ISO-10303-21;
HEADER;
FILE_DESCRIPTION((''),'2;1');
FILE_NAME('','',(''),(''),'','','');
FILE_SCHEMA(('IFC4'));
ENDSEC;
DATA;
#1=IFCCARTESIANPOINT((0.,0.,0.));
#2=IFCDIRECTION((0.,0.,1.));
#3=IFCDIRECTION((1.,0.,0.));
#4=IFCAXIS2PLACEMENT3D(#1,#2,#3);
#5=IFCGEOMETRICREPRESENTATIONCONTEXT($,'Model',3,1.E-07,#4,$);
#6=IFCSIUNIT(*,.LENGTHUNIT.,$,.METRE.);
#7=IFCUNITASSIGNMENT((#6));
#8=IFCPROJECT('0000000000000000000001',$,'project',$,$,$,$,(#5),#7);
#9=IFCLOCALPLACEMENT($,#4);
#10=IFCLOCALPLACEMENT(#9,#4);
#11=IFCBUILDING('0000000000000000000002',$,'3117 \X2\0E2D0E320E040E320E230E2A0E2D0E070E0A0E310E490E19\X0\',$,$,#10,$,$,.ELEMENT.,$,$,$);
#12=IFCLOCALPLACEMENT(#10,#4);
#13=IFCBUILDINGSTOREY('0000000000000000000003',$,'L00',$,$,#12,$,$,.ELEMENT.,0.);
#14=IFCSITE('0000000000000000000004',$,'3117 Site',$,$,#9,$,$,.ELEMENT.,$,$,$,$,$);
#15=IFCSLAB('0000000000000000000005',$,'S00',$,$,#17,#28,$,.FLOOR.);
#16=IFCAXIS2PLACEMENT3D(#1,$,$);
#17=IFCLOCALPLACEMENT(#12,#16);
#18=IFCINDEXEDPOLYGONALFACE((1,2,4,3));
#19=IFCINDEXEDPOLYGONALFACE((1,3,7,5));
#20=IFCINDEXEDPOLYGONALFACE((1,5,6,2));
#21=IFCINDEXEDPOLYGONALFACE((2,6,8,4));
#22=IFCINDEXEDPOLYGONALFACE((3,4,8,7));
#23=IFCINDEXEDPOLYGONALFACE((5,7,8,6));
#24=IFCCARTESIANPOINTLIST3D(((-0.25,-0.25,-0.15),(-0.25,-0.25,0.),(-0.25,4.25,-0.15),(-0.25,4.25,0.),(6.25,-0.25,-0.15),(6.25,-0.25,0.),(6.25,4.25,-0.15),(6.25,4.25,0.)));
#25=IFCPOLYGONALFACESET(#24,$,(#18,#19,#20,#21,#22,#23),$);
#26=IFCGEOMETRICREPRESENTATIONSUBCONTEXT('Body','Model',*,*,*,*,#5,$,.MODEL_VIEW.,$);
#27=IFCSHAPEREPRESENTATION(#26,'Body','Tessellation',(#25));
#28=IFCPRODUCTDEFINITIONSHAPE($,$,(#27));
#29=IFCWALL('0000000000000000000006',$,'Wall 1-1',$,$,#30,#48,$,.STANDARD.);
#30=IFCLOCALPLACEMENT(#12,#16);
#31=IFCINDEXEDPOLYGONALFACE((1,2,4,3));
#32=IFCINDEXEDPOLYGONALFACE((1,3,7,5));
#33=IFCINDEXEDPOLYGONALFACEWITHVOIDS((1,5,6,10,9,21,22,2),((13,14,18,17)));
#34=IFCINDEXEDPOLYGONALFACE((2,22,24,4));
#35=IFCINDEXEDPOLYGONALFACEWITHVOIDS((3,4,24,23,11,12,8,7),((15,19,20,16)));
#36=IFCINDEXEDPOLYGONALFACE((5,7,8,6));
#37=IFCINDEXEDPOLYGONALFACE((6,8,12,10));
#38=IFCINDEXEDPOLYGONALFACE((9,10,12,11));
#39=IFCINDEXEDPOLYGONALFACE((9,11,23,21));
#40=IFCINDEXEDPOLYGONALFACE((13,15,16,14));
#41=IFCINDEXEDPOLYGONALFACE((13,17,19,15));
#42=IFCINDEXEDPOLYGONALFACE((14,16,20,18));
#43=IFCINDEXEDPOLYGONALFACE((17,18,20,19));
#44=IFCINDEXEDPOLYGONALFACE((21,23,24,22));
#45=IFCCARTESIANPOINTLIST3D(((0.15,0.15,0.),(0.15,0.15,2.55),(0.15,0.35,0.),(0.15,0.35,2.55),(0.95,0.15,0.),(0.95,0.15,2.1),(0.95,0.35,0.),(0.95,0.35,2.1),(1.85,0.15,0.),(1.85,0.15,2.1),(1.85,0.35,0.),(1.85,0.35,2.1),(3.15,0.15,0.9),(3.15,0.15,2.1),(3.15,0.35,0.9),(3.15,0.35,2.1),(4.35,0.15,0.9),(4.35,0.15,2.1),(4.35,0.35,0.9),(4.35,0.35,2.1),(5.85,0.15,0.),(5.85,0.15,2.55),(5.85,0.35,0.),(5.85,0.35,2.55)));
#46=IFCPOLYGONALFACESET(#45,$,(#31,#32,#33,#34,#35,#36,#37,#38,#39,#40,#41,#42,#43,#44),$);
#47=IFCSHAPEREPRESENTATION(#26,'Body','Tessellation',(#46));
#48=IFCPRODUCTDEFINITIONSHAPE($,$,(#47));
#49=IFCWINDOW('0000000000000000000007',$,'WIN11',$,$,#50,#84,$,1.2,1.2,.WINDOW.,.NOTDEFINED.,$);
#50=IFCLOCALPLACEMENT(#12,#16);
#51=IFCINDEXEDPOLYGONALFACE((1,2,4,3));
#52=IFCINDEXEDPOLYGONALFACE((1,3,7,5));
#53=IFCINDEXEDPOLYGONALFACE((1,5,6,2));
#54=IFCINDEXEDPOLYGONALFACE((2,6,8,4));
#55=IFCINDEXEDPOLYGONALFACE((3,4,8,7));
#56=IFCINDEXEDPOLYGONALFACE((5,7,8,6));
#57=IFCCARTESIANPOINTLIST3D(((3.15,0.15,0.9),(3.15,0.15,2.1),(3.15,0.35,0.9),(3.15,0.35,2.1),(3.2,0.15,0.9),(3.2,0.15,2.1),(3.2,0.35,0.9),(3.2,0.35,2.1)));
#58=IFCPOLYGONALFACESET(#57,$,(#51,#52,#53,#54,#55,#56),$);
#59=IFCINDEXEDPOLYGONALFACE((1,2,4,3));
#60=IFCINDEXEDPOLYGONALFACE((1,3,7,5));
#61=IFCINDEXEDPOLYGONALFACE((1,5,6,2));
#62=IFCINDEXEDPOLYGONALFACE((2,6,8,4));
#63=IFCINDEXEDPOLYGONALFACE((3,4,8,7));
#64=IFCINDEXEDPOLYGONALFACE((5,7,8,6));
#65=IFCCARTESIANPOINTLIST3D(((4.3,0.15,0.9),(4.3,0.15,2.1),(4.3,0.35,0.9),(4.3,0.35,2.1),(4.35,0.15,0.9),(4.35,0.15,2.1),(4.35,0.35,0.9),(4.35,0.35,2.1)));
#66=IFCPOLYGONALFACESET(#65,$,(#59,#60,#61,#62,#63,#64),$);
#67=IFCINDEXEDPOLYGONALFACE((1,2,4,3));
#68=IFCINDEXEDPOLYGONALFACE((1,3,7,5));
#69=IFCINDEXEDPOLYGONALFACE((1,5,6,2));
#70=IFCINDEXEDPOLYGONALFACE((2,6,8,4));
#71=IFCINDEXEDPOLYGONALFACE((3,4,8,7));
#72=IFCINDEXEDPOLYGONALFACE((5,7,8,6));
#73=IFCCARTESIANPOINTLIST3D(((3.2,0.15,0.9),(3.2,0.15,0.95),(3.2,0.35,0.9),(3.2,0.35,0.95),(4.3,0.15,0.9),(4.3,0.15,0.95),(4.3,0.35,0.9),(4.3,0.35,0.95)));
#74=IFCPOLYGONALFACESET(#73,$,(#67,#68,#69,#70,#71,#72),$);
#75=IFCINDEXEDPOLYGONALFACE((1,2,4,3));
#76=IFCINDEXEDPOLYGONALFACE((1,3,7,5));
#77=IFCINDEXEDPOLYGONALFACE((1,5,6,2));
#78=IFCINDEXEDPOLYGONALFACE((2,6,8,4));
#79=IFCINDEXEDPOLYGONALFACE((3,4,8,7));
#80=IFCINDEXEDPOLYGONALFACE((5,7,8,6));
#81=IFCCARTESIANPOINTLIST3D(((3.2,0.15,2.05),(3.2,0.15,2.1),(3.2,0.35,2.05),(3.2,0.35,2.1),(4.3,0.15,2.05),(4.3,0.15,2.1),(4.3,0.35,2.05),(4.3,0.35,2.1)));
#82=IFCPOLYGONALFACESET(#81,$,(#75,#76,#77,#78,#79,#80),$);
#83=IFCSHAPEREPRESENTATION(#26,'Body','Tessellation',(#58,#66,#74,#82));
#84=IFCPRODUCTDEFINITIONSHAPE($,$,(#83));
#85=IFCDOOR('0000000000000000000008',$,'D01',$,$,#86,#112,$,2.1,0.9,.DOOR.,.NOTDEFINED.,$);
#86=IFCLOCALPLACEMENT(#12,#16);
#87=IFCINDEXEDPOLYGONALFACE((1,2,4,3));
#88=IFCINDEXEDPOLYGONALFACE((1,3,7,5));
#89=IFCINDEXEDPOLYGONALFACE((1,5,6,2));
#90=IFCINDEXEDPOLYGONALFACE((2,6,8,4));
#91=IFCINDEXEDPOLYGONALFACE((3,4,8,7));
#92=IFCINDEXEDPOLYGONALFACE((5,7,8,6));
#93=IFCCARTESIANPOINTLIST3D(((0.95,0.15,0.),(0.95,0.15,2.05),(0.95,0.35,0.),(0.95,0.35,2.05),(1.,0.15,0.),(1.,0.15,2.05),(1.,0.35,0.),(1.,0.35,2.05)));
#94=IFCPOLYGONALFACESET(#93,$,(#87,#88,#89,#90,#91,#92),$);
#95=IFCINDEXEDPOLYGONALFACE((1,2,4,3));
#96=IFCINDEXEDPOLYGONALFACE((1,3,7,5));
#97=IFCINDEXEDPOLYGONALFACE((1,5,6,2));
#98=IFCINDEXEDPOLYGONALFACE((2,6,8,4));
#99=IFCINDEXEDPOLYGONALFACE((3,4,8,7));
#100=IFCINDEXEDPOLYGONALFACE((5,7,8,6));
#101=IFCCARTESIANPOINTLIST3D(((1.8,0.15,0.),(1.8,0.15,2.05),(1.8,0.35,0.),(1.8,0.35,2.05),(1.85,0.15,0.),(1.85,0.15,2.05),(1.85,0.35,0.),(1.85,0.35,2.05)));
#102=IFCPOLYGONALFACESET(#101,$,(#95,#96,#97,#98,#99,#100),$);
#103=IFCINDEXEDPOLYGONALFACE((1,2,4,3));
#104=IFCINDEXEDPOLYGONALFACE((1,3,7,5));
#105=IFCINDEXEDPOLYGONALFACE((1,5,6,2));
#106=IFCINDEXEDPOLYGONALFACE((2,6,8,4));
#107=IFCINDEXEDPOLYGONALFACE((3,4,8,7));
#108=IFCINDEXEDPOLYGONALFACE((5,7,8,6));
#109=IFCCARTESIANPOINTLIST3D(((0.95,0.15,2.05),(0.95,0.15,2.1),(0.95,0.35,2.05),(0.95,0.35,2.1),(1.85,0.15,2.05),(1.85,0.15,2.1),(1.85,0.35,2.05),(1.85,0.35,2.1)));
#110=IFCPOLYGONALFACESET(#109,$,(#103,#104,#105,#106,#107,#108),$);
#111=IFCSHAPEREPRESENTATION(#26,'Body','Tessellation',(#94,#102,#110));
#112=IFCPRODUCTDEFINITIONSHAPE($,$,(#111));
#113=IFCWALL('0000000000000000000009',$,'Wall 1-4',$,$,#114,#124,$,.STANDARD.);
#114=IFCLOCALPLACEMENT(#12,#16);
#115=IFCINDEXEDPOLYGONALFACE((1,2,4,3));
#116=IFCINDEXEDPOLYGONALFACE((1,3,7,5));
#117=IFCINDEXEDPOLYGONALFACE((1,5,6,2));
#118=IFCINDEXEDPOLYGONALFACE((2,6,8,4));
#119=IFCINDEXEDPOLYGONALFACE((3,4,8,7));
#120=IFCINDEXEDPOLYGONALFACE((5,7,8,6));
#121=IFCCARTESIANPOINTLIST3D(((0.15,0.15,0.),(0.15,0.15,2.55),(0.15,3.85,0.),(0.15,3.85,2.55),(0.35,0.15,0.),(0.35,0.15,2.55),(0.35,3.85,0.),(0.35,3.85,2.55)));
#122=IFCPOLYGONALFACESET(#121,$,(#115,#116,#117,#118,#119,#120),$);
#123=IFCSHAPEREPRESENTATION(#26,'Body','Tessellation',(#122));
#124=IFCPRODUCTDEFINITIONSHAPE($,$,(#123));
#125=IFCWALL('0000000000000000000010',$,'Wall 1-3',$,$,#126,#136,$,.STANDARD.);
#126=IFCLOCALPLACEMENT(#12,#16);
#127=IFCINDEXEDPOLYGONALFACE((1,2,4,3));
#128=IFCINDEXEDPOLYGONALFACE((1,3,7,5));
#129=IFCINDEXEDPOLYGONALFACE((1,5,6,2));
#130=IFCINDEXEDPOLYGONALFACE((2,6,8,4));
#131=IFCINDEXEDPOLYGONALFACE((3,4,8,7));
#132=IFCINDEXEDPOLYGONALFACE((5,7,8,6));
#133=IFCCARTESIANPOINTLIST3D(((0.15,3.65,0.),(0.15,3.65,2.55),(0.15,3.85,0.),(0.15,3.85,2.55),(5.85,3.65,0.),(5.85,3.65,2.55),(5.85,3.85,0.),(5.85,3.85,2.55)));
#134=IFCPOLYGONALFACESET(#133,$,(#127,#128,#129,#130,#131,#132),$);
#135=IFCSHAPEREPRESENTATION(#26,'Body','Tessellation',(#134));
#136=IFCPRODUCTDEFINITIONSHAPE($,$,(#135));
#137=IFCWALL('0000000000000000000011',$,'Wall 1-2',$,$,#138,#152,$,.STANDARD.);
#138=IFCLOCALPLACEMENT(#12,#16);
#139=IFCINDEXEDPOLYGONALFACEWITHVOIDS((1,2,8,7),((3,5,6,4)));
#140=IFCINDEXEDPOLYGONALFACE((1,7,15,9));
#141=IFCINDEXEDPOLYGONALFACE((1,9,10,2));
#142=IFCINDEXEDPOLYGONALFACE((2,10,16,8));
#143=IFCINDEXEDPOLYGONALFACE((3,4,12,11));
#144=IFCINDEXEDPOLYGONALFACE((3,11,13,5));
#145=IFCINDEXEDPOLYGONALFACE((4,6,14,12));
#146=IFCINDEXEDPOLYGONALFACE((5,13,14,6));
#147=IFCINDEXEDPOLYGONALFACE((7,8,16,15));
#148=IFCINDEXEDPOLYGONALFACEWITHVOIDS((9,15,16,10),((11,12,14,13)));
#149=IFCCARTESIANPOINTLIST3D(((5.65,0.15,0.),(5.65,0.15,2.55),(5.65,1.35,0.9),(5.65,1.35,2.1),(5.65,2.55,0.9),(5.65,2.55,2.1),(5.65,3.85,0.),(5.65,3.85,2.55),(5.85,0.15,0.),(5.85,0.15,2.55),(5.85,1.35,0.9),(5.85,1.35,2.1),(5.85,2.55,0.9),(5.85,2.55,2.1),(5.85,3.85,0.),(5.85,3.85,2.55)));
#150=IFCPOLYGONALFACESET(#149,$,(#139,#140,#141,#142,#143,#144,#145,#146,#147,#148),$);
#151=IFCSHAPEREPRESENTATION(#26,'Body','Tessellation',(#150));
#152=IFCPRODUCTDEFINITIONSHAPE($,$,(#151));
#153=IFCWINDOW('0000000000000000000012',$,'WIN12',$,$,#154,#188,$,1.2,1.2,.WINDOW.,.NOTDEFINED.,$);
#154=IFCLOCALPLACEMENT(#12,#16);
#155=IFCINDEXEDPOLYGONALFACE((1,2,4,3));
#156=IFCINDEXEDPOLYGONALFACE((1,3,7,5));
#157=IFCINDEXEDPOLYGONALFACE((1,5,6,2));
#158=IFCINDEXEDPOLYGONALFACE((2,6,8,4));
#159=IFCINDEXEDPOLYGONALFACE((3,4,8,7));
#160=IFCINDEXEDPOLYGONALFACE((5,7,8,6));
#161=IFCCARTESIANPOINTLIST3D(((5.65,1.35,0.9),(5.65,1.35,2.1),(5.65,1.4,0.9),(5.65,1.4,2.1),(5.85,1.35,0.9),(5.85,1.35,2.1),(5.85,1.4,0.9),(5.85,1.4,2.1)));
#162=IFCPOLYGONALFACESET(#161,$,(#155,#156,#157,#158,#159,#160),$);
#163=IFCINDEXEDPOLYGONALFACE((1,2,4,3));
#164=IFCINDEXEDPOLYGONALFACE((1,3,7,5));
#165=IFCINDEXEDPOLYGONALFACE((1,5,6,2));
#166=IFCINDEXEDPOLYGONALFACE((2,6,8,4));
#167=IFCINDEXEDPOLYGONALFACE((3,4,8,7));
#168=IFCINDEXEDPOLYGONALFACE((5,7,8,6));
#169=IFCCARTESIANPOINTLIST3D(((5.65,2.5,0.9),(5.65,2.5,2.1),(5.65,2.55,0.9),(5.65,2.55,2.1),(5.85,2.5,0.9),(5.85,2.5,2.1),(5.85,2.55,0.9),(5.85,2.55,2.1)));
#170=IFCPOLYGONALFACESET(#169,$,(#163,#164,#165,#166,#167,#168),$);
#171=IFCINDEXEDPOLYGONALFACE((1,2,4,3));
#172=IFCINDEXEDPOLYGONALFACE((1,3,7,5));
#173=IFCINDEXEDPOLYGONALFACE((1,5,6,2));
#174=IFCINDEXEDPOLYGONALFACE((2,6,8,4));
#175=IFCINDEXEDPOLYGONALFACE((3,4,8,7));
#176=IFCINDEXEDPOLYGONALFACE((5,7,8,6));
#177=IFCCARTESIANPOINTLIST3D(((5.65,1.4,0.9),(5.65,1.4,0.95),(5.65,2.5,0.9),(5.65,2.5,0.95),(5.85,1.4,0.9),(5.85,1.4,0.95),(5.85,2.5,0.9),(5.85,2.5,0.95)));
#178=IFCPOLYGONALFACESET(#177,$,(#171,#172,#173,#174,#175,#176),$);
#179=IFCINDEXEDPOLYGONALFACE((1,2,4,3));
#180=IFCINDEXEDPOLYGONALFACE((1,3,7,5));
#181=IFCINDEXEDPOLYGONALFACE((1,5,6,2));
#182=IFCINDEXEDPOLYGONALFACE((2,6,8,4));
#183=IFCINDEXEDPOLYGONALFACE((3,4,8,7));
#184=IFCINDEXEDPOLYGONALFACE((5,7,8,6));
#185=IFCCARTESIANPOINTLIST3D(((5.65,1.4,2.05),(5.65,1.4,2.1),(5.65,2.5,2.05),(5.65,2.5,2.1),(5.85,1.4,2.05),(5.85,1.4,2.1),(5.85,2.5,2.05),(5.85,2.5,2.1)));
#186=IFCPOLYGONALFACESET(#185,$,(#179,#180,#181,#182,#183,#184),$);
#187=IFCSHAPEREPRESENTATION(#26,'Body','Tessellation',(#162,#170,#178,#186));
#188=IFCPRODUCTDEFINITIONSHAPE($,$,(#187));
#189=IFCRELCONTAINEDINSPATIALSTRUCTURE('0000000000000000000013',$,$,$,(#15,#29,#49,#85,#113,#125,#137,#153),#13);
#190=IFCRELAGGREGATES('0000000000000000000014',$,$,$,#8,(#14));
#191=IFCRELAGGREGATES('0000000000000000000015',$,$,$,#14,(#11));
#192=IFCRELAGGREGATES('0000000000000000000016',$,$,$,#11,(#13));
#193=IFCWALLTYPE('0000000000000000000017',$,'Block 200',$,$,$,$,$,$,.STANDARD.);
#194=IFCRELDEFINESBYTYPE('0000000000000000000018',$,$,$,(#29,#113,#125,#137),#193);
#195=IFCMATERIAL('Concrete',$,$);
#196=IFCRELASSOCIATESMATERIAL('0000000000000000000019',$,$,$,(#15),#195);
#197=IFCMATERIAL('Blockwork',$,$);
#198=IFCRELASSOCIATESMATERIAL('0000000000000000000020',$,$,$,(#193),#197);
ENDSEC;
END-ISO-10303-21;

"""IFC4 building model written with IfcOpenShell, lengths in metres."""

from ifc_helpers import new_model, si_unit, frame, origin_with_axes, place, context, subcontext, project, spatial, polyline, outline, extrude, material, type_object, element, fill, save


model = new_model("IFC4")

# Units and contexts
model_context = context("Model", 3, precision=1e-07, world=origin_with_axes())
body_context = subcontext(model_context, "Body", "Model", "MODEL_VIEW")
ifc_project = project(units=[si_unit("LENGTHUNIT", "METRE")], contexts=[model_context])

# Site, building, storey
site_placement = place(None, origin_with_axes())
site = spatial("IfcSite", under=ifc_project, at=site_placement, Name="3117 Site", CompositionType="ELEMENT")
building_placement = place(site_placement, origin_with_axes())
building = spatial("IfcBuilding", under=site, at=building_placement, Name="3117 อาคารสองชั้น", CompositionType="ELEMENT")
storey_placement = place(building_placement, origin_with_axes())
storey = spatial("IfcBuildingStorey", under=building, at=storey_placement, Name="L00", CompositionType="ELEMENT", Elevation=0.0)

# Slab
ifc_material_1 = material(Name="Concrete")
slab_placement = place(storey_placement, frame((0.0, 0.0, -0.15), z_axis=(0.0, 0.0, 1.0), x_axis=(1.0, 0.0, 0.0)))
element("IfcSlab", 1, at=slab_placement, inside=storey, material=ifc_material_1, Name="S00", PredefinedType="FLOOR", context=body_context, shape_type="SweptSolid", body=[
    extrude(outline(polyline([(-0.25, -0.25), (6.25, -0.25), (6.25, 4.25), (-0.25, 4.25), (-0.25, -0.25)])), origin_with_axes(), (0.0, 0.0, 1.0), 0.15),
])

# Wall, openings, window, door
ifc_material_2 = material(Name="Blockwork")
wall_type = type_object("IfcWallType", Name="Block 200", PredefinedType="STANDARD", material=ifc_material_2)
wall_1_placement = place(storey_placement, frame((0.15, 0.15, 0.0), z_axis=(0.0, 0.0, 1.0), x_axis=(1.0, 0.0, 0.0)))
wall_1 = element("IfcWall", 2, at=wall_1_placement, inside=storey, type_object=wall_type, Name="Wall 1-1", PredefinedType="STANDARD", context=body_context, shape_type="SweptSolid", body=[
    extrude(outline(polyline([(0.0, 0.0), (5.7, 0.0), (5.7, 0.2), (0.0, 0.2), (0.0, 0.0)])), origin_with_axes(), (0.0, 0.0, 1.0), 2.55),
])
opening_1_placement = place(wall_1_placement, frame((3.0, 0.0, 0.9), z_axis=(0.0, 0.0, 1.0), x_axis=(1.0, 0.0, 0.0)))
opening_1 = element("IfcOpeningElement", 3, at=opening_1_placement, cuts=wall_1, PredefinedType="OPENING", context=body_context, shape_type="SweptSolid", body=[
    extrude(outline(polyline([(0.0, 0.0), (1.2, 0.0), (1.2, 0.2), (0.0, 0.2), (0.0, 0.0)])), origin_with_axes(), (0.0, 0.0, 1.0), 1.2),
])
opening_2_placement = place(wall_1_placement, frame((0.8, 0.0, 0.0), z_axis=(0.0, 0.0, 1.0), x_axis=(1.0, 0.0, 0.0)))
opening_2 = element("IfcOpeningElement", 4, at=opening_2_placement, cuts=wall_1, PredefinedType="OPENING", context=body_context, shape_type="SweptSolid", body=[
    extrude(outline(polyline([(0.0, 0.0), (0.9, 0.0), (0.9, 0.2), (0.0, 0.2), (0.0, 0.0)])), origin_with_axes(), (0.0, 0.0, 1.0), 2.1),
])
window_1_placement = place(opening_1_placement, frame((0.0, 0.0, 0.0), z_axis=(0.0, 0.0, 1.0), x_axis=(1.0, 0.0, 0.0)))
window_1 = element("IfcWindow", 5, at=window_1_placement, inside=storey, Name="WIN11", OverallHeight=1.2, OverallWidth=1.2, PartitioningType="NOTDEFINED", PredefinedType="WINDOW", context=body_context, shape_type="SweptSolid", body=[
    extrude(outline(polyline([(0.0, 0.0), (0.05, 0.0), (0.05, 0.2), (0.0, 0.2), (0.0, 0.0)])), origin_with_axes(), (0.0, 0.0, 1.0), 1.2),
    extrude(outline(polyline([(0.0, 0.0), (0.05, 0.0), (0.05, 0.2), (0.0, 0.2), (0.0, 0.0)])), frame((1.15, 0.0, 0.0), z_axis=(0.0, 0.0, 1.0), x_axis=(1.0, 0.0, 0.0)), (0.0, 0.0, 1.0), 1.2),
    extrude(outline(polyline([(0.0, 0.0), (1.1, 0.0), (1.1, 0.2), (0.0, 0.2), (0.0, 0.0)])), frame((0.05, 0.0, 0.0), z_axis=(0.0, 0.0, 1.0), x_axis=(1.0, 0.0, 0.0)), (0.0, 0.0, 1.0), 0.05),
    extrude(outline(polyline([(0.0, 0.0), (1.1, 0.0), (1.1, 0.2), (0.0, 0.2), (0.0, 0.0)])), frame((0.05, 0.0, 1.15), z_axis=(0.0, 0.0, 1.0), x_axis=(1.0, 0.0, 0.0)), (0.0, 0.0, 1.0), 0.05),
])
fill(opening_1, window_1)
door_placement = place(opening_2_placement, frame((0.0, 0.0, 0.0), z_axis=(0.0, 0.0, 1.0), x_axis=(1.0, 0.0, 0.0)))
door = element("IfcDoor", 6, at=door_placement, inside=storey, Name="D01", OperationType="NOTDEFINED", OverallHeight=2.1, OverallWidth=0.9, PredefinedType="DOOR", context=body_context, shape_type="SweptSolid", body=[
    extrude(outline(polyline([(0.0, 0.0), (0.05, 0.0), (0.05, 0.2), (0.0, 0.2), (0.0, 0.0)])), origin_with_axes(), (0.0, 0.0, 1.0), 2.05),
    extrude(outline(polyline([(0.0, 0.0), (0.05, 0.0), (0.05, 0.2), (0.0, 0.2), (0.0, 0.0)])), frame((0.85, 0.0, 0.0), z_axis=(0.0, 0.0, 1.0), x_axis=(1.0, 0.0, 0.0)), (0.0, 0.0, 1.0), 2.05),
    extrude(outline(polyline([(0.0, 0.0), (0.9, 0.0), (0.9, 0.2), (0.0, 0.2), (0.0, 0.0)])), frame((0.0, 0.0, 2.05), z_axis=(0.0, 0.0, 1.0), x_axis=(1.0, 0.0, 0.0)), (0.0, 0.0, 1.0), 0.05),
])
fill(opening_2, door)

# Walls
wall_2_placement = place(storey_placement, frame((0.15, 3.85, 0.0), z_axis=(0.0, 0.0, 1.0), x_axis=(0.0, -1.0, 0.0)))
element("IfcWall", 7, at=wall_2_placement, inside=storey, type_object=wall_type, Name="Wall 1-4", PredefinedType="STANDARD", context=body_context, shape_type="SweptSolid", body=[
    extrude(outline(polyline([(0.0, 0.0), (3.7, 0.0), (3.7, 0.2), (0.0, 0.2), (0.0, 0.0)])), origin_with_axes(), (0.0, 0.0, 1.0), 2.55),
])
wall_3_placement = place(storey_placement, frame((5.85, 3.85, 0.0), z_axis=(0.0, 0.0, 1.0), x_axis=(-1.0, 0.0, 0.0)))
element("IfcWall", 8, at=wall_3_placement, inside=storey, type_object=wall_type, Name="Wall 1-3", PredefinedType="STANDARD", context=body_context, shape_type="SweptSolid", body=[
    extrude(outline(polyline([(0.0, 0.0), (5.7, 0.0), (5.7, 0.2), (0.0, 0.2), (0.0, 0.0)])), origin_with_axes(), (0.0, 0.0, 1.0), 2.55),
])

# Wall, opening, window
wall_4_placement = place(storey_placement, frame((5.85, 0.15, 0.0), z_axis=(0.0, 0.0, 1.0), x_axis=(0.0, 1.0, 0.0)))
wall_4 = element("IfcWall", 9, at=wall_4_placement, inside=storey, type_object=wall_type, Name="Wall 1-2", PredefinedType="STANDARD", context=body_context, shape_type="SweptSolid", body=[
    extrude(outline(polyline([(0.0, 0.0), (3.7, 0.0), (3.7, 0.2), (0.0, 0.2), (0.0, 0.0)])), origin_with_axes(), (0.0, 0.0, 1.0), 2.55),
])
opening_3_placement = place(wall_4_placement, frame((1.2, 0.0, 0.9), z_axis=(0.0, 0.0, 1.0), x_axis=(1.0, 0.0, 0.0)))
opening_3 = element("IfcOpeningElement", 10, at=opening_3_placement, cuts=wall_4, PredefinedType="OPENING", context=body_context, shape_type="SweptSolid", body=[
    extrude(outline(polyline([(0.0, 0.0), (1.2, 0.0), (1.2, 0.2), (0.0, 0.2), (0.0, 0.0)])), origin_with_axes(), (0.0, 0.0, 1.0), 1.2),
])
window_2_placement = place(opening_3_placement, frame((0.0, 0.0, 0.0), z_axis=(0.0, 0.0, 1.0), x_axis=(1.0, 0.0, 0.0)))
window_2 = element("IfcWindow", 11, at=window_2_placement, inside=storey, Name="WIN12", OverallHeight=1.2, OverallWidth=1.2, PartitioningType="NOTDEFINED", PredefinedType="WINDOW", context=body_context, shape_type="SweptSolid", body=[
    extrude(outline(polyline([(0.0, 0.0), (0.05, 0.0), (0.05, 0.2), (0.0, 0.2), (0.0, 0.0)])), origin_with_axes(), (0.0, 0.0, 1.0), 1.2),
    extrude(outline(polyline([(0.0, 0.0), (0.05, 0.0), (0.05, 0.2), (0.0, 0.2), (0.0, 0.0)])), frame((1.15, 0.0, 0.0), z_axis=(0.0, 0.0, 1.0), x_axis=(1.0, 0.0, 0.0)), (0.0, 0.0, 1.0), 1.2),
    extrude(outline(polyline([(0.0, 0.0), (1.1, 0.0), (1.1, 0.2), (0.0, 0.2), (0.0, 0.0)])), frame((0.05, 0.0, 0.0), z_axis=(0.0, 0.0, 1.0), x_axis=(1.0, 0.0, 0.0)), (0.0, 0.0, 1.0), 0.05),
    extrude(outline(polyline([(0.0, 0.0), (1.1, 0.0), (1.1, 0.2), (0.0, 0.2), (0.0, 0.0)])), frame((0.05, 0.0, 1.15), z_axis=(0.0, 0.0, 1.0), x_axis=(1.0, 0.0, 0.0)), (0.0, 0.0, 1.0), 0.05),
])
fill(opening_3, window_2)

save(model, "model.ifc")
